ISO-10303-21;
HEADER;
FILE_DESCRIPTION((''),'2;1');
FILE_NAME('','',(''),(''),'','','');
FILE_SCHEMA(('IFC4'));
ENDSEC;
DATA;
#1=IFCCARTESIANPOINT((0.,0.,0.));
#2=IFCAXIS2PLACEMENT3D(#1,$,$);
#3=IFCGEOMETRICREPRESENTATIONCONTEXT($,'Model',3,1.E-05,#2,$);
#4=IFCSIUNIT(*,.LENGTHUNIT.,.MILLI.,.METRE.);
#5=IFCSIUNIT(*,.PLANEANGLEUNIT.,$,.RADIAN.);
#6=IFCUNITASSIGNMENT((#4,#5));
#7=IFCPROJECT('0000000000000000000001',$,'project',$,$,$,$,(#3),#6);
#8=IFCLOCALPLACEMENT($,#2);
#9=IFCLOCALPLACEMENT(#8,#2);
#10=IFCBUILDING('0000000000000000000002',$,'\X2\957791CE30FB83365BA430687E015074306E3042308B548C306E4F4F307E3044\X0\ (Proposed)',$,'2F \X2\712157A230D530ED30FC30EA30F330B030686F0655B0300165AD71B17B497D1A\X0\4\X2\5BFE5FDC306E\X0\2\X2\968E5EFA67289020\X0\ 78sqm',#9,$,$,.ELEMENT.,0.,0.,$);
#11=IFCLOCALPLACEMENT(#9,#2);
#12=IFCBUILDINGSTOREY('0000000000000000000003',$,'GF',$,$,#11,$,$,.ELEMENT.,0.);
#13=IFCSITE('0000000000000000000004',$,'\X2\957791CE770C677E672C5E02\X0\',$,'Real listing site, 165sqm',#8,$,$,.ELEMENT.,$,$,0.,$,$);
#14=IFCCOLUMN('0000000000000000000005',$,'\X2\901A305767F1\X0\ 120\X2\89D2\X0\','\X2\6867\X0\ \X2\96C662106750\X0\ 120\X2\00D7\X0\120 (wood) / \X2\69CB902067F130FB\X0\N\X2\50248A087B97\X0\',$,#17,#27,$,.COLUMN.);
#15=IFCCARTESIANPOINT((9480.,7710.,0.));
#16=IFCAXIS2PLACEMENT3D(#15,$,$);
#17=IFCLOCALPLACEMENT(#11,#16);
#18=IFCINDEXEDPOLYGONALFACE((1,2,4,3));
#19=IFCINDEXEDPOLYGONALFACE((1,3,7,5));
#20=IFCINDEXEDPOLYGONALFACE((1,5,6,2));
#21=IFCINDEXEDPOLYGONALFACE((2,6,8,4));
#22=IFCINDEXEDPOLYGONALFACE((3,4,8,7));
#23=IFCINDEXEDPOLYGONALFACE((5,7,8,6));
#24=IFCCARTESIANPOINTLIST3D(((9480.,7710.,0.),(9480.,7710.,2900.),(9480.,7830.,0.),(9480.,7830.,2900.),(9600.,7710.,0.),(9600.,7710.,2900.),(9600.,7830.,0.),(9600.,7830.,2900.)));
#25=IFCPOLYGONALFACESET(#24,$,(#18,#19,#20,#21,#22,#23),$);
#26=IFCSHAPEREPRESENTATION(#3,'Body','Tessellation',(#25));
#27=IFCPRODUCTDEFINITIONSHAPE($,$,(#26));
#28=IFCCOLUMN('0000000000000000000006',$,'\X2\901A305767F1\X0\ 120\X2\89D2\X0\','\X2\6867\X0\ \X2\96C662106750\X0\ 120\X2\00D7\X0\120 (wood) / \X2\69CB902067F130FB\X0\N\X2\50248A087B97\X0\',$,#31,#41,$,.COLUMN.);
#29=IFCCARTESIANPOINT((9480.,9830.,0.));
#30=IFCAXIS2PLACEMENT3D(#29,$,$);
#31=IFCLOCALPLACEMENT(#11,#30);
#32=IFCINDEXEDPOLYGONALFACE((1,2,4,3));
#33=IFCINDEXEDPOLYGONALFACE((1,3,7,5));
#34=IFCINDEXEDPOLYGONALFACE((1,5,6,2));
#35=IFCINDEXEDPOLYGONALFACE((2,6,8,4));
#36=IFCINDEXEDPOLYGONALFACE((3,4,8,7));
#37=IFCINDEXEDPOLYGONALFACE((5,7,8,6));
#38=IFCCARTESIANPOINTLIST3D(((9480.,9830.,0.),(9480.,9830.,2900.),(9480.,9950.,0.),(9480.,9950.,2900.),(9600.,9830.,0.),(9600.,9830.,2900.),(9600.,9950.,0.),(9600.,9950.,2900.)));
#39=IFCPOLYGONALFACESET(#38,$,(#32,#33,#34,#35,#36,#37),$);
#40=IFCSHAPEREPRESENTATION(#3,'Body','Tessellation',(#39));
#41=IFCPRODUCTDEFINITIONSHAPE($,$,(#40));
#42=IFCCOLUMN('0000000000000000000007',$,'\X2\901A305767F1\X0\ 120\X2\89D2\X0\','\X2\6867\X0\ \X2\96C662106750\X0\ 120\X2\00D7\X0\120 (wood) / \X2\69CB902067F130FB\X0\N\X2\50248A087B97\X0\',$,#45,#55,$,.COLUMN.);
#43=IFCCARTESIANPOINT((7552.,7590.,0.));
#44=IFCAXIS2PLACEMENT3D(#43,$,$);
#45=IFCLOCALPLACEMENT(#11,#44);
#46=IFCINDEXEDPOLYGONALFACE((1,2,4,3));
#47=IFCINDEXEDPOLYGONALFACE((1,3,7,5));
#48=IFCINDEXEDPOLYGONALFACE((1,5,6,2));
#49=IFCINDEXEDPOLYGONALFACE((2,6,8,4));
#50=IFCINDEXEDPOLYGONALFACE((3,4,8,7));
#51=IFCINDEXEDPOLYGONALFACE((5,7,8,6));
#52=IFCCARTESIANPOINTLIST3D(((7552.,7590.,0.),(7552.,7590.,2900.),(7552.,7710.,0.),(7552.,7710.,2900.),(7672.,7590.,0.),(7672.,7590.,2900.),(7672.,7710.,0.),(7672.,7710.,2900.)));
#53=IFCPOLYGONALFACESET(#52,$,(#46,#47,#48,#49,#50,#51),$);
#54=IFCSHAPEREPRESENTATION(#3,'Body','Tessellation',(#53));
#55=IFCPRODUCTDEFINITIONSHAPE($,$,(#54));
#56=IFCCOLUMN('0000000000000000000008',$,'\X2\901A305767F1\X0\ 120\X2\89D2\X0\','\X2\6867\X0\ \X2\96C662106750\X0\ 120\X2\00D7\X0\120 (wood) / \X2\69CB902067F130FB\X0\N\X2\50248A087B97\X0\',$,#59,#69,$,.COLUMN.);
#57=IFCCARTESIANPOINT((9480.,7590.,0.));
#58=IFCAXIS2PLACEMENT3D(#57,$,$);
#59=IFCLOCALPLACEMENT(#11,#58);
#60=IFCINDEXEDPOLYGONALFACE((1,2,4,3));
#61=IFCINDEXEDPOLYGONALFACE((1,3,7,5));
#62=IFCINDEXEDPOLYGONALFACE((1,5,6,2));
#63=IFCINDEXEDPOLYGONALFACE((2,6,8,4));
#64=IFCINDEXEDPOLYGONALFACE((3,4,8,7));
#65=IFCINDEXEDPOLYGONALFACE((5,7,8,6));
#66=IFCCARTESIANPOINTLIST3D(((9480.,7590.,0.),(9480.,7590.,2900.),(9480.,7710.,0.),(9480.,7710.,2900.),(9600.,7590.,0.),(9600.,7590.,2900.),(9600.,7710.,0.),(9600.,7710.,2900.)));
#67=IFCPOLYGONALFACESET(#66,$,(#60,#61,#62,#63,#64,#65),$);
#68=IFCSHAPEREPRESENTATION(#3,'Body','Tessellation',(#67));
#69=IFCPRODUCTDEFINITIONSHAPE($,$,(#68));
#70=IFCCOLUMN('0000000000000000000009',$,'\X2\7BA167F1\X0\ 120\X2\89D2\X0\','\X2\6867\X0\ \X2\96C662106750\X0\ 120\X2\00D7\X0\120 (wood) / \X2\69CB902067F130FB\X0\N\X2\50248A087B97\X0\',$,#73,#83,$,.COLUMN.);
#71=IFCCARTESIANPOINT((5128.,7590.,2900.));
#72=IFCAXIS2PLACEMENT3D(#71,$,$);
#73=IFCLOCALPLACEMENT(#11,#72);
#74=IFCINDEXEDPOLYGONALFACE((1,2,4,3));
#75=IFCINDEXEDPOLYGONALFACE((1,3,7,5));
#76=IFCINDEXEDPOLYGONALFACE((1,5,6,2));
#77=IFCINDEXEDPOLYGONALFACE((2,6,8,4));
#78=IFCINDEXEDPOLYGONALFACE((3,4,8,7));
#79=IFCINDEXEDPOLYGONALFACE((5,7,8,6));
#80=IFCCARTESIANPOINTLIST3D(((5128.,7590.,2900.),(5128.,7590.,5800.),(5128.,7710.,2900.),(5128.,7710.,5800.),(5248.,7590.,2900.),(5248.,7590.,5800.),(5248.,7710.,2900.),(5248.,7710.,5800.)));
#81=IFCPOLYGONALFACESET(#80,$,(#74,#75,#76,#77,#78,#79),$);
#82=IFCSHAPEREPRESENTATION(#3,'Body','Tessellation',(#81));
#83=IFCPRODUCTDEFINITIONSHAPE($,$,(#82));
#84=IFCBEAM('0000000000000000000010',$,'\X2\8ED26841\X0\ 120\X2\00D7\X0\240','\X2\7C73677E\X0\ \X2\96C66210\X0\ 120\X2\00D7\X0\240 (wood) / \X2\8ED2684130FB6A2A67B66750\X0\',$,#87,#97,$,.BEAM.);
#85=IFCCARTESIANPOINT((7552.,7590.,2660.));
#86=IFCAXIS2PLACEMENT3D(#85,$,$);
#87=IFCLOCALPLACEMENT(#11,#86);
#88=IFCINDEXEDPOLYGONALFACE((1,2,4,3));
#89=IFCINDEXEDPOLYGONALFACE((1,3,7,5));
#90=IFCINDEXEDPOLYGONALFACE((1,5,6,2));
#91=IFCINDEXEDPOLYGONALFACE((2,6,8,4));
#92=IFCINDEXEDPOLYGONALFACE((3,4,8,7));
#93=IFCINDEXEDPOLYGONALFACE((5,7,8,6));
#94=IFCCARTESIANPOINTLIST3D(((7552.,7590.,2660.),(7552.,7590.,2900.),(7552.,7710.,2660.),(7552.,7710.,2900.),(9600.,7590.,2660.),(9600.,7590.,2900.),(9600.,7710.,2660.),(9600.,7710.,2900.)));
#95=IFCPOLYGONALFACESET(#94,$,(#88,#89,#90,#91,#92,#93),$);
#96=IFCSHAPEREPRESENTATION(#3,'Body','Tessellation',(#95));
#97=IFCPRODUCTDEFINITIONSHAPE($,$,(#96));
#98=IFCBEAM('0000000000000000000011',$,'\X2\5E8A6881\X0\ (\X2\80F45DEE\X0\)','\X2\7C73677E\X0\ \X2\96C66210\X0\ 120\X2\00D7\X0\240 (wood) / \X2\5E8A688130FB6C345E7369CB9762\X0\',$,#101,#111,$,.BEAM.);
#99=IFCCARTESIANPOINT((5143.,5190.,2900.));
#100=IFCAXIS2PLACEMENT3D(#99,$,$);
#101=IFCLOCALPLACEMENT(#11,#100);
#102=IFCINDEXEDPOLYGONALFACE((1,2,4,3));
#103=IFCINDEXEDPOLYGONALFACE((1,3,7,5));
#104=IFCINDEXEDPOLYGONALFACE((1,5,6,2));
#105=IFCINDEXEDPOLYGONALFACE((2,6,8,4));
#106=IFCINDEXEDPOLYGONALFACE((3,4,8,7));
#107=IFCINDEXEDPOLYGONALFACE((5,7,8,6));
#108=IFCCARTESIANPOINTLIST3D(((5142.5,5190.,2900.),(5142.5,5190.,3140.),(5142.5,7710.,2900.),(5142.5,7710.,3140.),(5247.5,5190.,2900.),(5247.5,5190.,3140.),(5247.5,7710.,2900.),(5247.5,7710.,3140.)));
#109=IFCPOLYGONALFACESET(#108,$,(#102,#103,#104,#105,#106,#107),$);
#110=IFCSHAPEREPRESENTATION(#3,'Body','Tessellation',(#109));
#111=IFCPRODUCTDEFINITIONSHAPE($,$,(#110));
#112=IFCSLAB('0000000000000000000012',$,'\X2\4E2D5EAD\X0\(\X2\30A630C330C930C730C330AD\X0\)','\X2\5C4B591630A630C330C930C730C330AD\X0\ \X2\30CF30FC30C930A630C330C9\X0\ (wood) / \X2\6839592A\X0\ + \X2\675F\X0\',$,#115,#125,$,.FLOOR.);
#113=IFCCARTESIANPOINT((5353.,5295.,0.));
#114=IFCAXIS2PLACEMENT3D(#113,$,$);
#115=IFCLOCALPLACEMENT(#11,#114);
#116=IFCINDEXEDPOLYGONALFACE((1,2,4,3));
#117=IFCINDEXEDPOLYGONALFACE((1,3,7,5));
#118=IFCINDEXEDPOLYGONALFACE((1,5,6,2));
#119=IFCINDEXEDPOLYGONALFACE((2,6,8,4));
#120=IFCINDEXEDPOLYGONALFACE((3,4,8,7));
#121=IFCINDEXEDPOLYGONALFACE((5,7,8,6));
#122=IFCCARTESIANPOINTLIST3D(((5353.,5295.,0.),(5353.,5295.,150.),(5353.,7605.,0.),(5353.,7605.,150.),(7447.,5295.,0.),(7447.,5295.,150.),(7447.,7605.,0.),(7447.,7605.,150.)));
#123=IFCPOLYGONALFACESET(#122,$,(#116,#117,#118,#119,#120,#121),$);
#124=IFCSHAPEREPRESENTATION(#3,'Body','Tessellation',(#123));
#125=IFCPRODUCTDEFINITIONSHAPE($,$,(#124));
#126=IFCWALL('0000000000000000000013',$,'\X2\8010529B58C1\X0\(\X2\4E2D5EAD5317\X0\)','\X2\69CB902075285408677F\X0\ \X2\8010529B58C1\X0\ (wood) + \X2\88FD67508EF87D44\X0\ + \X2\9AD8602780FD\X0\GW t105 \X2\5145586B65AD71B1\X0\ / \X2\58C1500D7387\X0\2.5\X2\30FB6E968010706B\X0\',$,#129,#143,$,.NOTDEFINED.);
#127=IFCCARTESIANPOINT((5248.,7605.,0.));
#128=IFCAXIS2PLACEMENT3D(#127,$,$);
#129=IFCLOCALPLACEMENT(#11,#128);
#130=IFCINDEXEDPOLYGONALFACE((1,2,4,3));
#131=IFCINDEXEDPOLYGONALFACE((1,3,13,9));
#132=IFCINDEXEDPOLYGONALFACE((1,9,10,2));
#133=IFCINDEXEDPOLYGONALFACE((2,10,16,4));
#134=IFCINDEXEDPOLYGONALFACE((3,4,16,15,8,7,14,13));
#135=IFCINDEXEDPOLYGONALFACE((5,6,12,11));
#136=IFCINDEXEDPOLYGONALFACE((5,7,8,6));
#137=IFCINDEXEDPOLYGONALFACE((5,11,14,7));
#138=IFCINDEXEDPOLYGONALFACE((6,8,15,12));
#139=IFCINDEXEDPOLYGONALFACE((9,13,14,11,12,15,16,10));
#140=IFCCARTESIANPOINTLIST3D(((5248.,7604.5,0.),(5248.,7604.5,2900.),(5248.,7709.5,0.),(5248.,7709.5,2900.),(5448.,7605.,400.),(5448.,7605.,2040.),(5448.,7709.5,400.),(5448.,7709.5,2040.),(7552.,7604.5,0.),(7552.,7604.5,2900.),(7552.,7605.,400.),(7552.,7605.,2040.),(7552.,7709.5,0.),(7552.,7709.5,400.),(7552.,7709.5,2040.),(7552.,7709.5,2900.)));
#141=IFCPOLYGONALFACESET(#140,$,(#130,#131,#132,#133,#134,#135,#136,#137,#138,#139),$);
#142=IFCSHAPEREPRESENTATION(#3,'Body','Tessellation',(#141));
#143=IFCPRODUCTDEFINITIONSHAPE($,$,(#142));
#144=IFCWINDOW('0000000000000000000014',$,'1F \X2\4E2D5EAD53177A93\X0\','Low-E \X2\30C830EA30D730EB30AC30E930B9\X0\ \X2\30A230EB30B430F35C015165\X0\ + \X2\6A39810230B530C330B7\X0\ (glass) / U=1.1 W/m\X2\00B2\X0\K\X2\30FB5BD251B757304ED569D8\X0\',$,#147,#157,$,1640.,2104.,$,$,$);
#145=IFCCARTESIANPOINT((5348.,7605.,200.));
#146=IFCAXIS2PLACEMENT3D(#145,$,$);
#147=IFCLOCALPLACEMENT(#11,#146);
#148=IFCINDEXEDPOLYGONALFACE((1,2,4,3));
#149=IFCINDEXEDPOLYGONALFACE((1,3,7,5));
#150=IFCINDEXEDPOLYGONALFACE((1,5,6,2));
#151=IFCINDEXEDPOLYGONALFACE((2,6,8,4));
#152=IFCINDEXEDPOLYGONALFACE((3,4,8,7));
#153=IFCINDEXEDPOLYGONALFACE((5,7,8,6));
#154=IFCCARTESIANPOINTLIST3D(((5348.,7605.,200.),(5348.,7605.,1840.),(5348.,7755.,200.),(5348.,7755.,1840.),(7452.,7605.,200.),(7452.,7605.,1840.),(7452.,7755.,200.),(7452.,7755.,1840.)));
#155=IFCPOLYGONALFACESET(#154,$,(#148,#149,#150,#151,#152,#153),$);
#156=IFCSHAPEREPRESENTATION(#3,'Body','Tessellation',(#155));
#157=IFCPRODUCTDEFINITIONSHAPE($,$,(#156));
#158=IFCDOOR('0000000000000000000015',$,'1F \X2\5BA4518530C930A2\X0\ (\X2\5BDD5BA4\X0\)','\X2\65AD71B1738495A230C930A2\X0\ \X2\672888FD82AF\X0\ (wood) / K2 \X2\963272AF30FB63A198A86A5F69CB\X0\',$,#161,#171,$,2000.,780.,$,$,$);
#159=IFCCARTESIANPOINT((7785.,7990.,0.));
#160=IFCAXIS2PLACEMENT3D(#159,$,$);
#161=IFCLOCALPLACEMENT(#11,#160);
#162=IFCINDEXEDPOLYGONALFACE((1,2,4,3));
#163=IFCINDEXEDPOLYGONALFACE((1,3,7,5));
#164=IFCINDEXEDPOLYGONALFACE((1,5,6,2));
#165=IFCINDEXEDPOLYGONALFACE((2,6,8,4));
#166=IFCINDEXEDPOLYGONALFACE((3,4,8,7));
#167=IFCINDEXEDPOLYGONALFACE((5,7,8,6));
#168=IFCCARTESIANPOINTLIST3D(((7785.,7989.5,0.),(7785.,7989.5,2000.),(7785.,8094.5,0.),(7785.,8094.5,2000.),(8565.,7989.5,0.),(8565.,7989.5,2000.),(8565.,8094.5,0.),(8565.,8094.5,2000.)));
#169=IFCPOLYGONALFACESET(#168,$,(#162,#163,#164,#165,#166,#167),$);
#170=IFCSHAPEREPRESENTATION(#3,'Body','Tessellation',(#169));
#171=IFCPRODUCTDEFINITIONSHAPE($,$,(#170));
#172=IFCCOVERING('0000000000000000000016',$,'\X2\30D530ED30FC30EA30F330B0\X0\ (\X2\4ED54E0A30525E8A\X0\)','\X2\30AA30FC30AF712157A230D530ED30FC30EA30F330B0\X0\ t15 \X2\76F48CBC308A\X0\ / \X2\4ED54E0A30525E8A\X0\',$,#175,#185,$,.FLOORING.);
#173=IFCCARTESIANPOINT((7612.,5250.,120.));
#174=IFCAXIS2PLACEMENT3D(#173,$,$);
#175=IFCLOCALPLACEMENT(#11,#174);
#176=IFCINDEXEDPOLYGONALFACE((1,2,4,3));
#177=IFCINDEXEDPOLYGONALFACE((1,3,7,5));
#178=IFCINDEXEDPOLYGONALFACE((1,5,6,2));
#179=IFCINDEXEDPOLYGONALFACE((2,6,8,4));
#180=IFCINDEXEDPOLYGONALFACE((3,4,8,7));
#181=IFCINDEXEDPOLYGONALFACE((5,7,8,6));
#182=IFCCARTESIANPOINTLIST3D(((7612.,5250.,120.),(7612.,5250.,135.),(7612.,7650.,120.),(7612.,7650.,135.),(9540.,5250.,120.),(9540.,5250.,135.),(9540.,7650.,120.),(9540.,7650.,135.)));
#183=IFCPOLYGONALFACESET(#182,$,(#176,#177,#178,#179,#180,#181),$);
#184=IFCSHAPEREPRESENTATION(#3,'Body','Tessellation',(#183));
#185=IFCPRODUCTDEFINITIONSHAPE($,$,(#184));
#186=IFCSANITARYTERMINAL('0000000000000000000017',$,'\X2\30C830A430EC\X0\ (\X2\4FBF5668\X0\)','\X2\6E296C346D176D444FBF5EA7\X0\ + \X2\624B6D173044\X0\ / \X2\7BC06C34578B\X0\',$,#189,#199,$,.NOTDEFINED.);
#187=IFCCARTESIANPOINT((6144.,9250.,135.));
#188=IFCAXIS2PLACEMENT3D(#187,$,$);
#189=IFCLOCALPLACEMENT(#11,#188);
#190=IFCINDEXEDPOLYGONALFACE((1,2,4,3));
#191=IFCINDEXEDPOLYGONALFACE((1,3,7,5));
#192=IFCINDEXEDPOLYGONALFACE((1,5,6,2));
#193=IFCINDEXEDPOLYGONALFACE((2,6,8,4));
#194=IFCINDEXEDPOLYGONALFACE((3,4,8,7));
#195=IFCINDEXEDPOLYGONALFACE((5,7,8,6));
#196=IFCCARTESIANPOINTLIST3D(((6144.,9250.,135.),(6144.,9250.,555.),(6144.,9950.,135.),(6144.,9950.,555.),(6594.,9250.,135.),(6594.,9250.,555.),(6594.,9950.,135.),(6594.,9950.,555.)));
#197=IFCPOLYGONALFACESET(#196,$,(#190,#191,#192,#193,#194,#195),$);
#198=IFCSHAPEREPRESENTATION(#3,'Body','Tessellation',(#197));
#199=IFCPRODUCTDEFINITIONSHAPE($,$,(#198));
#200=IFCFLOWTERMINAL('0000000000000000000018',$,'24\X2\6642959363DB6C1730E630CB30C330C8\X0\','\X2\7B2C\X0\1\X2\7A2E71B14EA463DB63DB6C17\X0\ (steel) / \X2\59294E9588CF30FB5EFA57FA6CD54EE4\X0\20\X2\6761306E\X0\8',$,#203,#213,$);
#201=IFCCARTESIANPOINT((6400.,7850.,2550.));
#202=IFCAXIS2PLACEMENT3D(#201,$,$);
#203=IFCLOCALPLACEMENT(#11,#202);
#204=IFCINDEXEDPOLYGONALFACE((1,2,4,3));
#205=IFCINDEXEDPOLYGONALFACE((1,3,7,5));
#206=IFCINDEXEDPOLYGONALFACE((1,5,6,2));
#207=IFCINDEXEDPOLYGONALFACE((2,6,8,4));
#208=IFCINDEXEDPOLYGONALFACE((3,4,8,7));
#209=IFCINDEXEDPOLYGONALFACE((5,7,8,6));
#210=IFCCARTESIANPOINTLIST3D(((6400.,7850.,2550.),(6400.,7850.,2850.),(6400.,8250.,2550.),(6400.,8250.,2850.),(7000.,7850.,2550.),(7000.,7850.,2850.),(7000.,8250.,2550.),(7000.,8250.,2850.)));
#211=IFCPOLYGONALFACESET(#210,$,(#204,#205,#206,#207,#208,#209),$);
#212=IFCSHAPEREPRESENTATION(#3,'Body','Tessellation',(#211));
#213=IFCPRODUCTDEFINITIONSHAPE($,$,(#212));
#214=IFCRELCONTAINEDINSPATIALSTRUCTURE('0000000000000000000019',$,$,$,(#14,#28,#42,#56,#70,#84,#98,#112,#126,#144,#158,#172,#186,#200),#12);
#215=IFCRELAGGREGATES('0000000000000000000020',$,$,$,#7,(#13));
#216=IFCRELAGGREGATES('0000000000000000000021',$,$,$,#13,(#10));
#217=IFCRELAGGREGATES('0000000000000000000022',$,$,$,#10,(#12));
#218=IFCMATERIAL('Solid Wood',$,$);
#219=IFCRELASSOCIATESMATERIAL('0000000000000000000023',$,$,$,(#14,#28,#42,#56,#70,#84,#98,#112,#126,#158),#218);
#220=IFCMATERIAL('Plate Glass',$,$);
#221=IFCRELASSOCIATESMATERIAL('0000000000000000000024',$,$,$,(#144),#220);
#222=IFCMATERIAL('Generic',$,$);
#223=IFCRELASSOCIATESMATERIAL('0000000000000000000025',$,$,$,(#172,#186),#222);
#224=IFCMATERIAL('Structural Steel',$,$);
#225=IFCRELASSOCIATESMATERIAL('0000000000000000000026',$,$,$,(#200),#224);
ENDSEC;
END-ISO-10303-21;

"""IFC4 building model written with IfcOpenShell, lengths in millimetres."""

from ifc_helpers import new_model, si_unit, frame, frame_2d, origin, place, context, project, spatial, rectangle, extrude, material, element, fill, save


model = new_model("IFC4")

# Units and contexts
model_context = context("Model", 3, precision=1e-05, world=origin())
ifc_project = project(units=[si_unit("LENGTHUNIT", "METRE", prefix="MILLI"), si_unit("PLANEANGLEUNIT", "RADIAN")], contexts=[model_context])

# Site, building, storey
site_placement = place(None, origin())
site = spatial("IfcSite", under=ifc_project, at=site_placement, Name="長野県松本市", ObjectType="Real listing site, 165sqm", CompositionType="ELEMENT", RefElevation=0.0)
building_placement = place(site_placement, origin())
building = spatial("IfcBuilding", under=site, at=building_placement, Name="長野・茶室と縁側のある和の住まい (Proposed)", ObjectType="2F 無垢フローリングと漆喰、断熱等級4対応の2階建木造 78sqm", CompositionType="ELEMENT", ElevationOfRefHeight=0.0, ElevationOfTerrain=0.0)
storey_placement = place(building_placement, origin())
storey = spatial("IfcBuildingStorey", under=building, at=storey_placement, Name="GF", CompositionType="ELEMENT", Elevation=0.0)

# Columns
ifc_material_1 = material(Name="Solid Wood")
column_1_placement = place(storey_placement, frame((9480.0, 7710.0, 0.0)))
element("IfcColumn", 1, at=column_1_placement, inside=storey, material=ifc_material_1, Name="通し柱 120角", Description="桧 集成材 120×120 (wood) / 構造柱・N値計算", PredefinedType="COLUMN", context=model_context, shape_type="SweptSolid", body=[
    extrude(rectangle(XDim=120.0, YDim=120.0, at=frame_2d((60.0, 60.0))), frame((9480.0, 7710.0, 0.0)), (0.0, 0.0, 1.0), 2900.0),
])
column_2_placement = place(storey_placement, frame((9480.0, 9830.0, 0.0)))
element("IfcColumn", 2, at=column_2_placement, inside=storey, material=ifc_material_1, Name="通し柱 120角", Description="桧 集成材 120×120 (wood) / 構造柱・N値計算", PredefinedType="COLUMN", context=model_context, shape_type="SweptSolid", body=[
    extrude(rectangle(XDim=120.0, YDim=120.0, at=frame_2d((60.0, 60.0))), frame((9480.0, 9830.0, 0.0)), (0.0, 0.0, 1.0), 2900.0),
])
column_3_placement = place(storey_placement, frame((7552.0, 7590.0, 0.0)))
element("IfcColumn", 3, at=column_3_placement, inside=storey, material=ifc_material_1, Name="通し柱 120角", Description="桧 集成材 120×120 (wood) / 構造柱・N値計算", PredefinedType="COLUMN", context=model_context, shape_type="SweptSolid", body=[
    extrude(rectangle(XDim=120.0, YDim=120.0, at=frame_2d((60.0, 60.0))), frame((7552.0, 7590.0, 0.0)), (0.0, 0.0, 1.0), 2900.0),
])
column_4_placement = place(storey_placement, frame((9480.0, 7590.0, 0.0)))
element("IfcColumn", 4, at=column_4_placement, inside=storey, material=ifc_material_1, Name="通し柱 120角", Description="桧 集成材 120×120 (wood) / 構造柱・N値計算", PredefinedType="COLUMN", context=model_context, shape_type="SweptSolid", body=[
    extrude(rectangle(XDim=120.0, YDim=120.0, at=frame_2d((60.0, 60.0))), frame((9480.0, 7590.0, 0.0)), (0.0, 0.0, 1.0), 2900.0),
])
column_5_placement = place(storey_placement, frame((5128.0, 7590.0, 2900.0)))
element("IfcColumn", 5, at=column_5_placement, inside=storey, material=ifc_material_1, Name="管柱 120角", Description="桧 集成材 120×120 (wood) / 構造柱・N値計算", PredefinedType="COLUMN", context=model_context, shape_type="SweptSolid", body=[
    extrude(rectangle(XDim=120.0, YDim=120.0, at=frame_2d((60.0, 60.0))), frame((5128.0, 7590.0, 2900.0)), (0.0, 0.0, 1.0), 2900.0),
])

# Beams
beam_1_placement = place(storey_placement, frame((7552.0, 7590.0, 2660.0)))
element("IfcBeam", 6, at=beam_1_placement, inside=storey, material=ifc_material_1, Name="軒桁 120×240", Description="米松 集成 120×240 (wood) / 軒桁・横架材", PredefinedType="BEAM", context=model_context, shape_type="SweptSolid", body=[
    extrude(rectangle(XDim=2048.0, YDim=120.0, at=frame_2d((1024.0, 60.0))), frame((7552.0, 7590.0, 2660.0)), (0.0, 0.0, 1.0), 240.0),
])
beam_2_placement = place(storey_placement, frame((5143.0, 5190.0, 2900.0)))
element("IfcBeam", 7, at=beam_2_placement, inside=storey, material=ifc_material_1, Name="床梁 (胴差)", Description="米松 集成 120×240 (wood) / 床梁・水平構面", PredefinedType="BEAM", context=model_context, shape_type="SweptSolid", body=[
    extrude(rectangle(XDim=105.0, YDim=2520.0, at=frame_2d((52.0, 1260.0))), frame((5143.0, 5190.0, 2900.0)), (0.0, 0.0, 1.0), 240.0),
])

# Slab
slab_placement = place(storey_placement, frame((5353.0, 5295.0, 0.0)))
element("IfcSlab", 8, at=slab_placement, inside=storey, material=ifc_material_1, Name="中庭(ウッドデッキ)", Description="屋外ウッドデッキ ハードウッド (wood) / 根太 + 束", PredefinedType="FLOOR", context=model_context, shape_type="SweptSolid", body=[
    extrude(rectangle(XDim=2094.0, YDim=2310.0, at=frame_2d((1047.0, 1155.0))), frame((5353.0, 5295.0, 0.0)), (0.0, 0.0, 1.0), 150.0),
])

# Wall, opening, window
wall_1_placement = place(storey_placement, frame((5248.0, 7605.0, 0.0)))
wall_1 = element("IfcWall", 9, at=wall_1_placement, inside=storey, material=ifc_material_1, Name="耐力壁(中庭北)", Description="構造用合板 耐力壁 (wood) + 製材軸組 + 高性能GW t105 充填断熱 / 壁倍率2.5・準耐火", PredefinedType="NOTDEFINED", context=model_context, shape_type="SweptSolid", body=[
    extrude(rectangle(XDim=2304.0, YDim=105.0, at=frame_2d((1152.0, 52.0))), frame((5248.0, 7605.0, 0.0)), (0.0, 0.0, 1.0), 2900.0),
])
opening_placement = place(storey_placement, frame((5348.0, 7605.0, 200.0)))
opening = element("IfcOpeningElement", 10, at=opening_placement, cuts=wall_1, PredefinedType="NOTDEFINED", context=model_context, shape_type="SweptSolid", body=[
    extrude(rectangle(XDim=2104.0, YDim=150.0, at=frame_2d((1052.0, 75.0))), frame((5348.0, 7605.0, 200.0)), (0.0, 0.0, 1.0), 1640.0),
])
ifc_material_2 = material(Name="Plate Glass")
window_placement = place(storey_placement, frame((5348.0, 7605.0, 200.0)))
window = element("IfcWindow", 11, at=window_placement, inside=storey, material=ifc_material_2, Name="1F 中庭北窓", Description="Low-E トリプルガラス アルゴン封入 + 樹脂サッシ (glass) / U=1.1 W/m²K・寒冷地仕様", OverallHeight=1640.0, OverallWidth=2104.0, context=model_context, shape_type="SweptSolid", body=[
    extrude(rectangle(XDim=2104.0, YDim=150.0, at=frame_2d((1052.0, 75.0))), frame((5348.0, 7605.0, 200.0)), (0.0, 0.0, 1.0), 1640.0),
])
fill(opening, window)

# Door
door_placement = place(storey_placement, frame((7785.0, 7990.0, 0.0)))
element("IfcDoor", 12, at=door_placement, inside=storey, material=ifc_material_1, Name="1F 室内ドア (寝室)", Description="断熱玄関ドア 木製芯 (wood) / K2 防犯・採風機構", OverallHeight=2000.0, OverallWidth=780.0, context=model_context, shape_type="SweptSolid", body=[
    extrude(rectangle(XDim=780.0, YDim=105.0, at=frame_2d((390.0, 52.0))), frame((7785.0, 7990.0, 0.0)), (0.0, 0.0, 1.0), 2000.0),
])

# Covering
ifc_material_3 = material(Name="Generic")
covering_placement = place(storey_placement, frame((7612.0, 5250.0, 120.0)))
element("IfcCovering", 13, at=covering_placement, inside=storey, material=ifc_material_3, Name="フローリング (仕上げ床)", Description="オーク無垢フローリング t15 直貼り / 仕上げ床", PredefinedType="FLOORING", context=model_context, shape_type="SweptSolid", body=[
    extrude(rectangle(XDim=1928.0, YDim=2400.0, at=frame_2d((964.0, 1200.0))), frame((7612.0, 5250.0, 120.0)), (0.0, 0.0, 1.0), 15.0),
])

# Sanitary terminal
sanitary_terminal_placement = place(storey_placement, frame((6144.0, 9250.0, 135.0)))
element("IfcSanitaryTerminal", 14, at=sanitary_terminal_placement, inside=storey, material=ifc_material_3, Name="トイレ (便器)", Description="温水洗浄便座 + 手洗い / 節水型", PredefinedType="NOTDEFINED", context=model_context, shape_type="SweptSolid", body=[
    extrude(rectangle(XDim=450.0, YDim=700.0, at=frame_2d((225.0, 350.0))), frame((6144.0, 9250.0, 135.0)), (0.0, 0.0, 1.0), 420.0),
])

# Flow terminal
ifc_material_4 = material(Name="Structural Steel")
flow_terminal_placement = place(storey_placement, frame((6400.0, 7850.0, 2550.0)))
element("IfcFlowTerminal", 15, at=flow_terminal_placement, inside=storey, material=ifc_material_4, Name="24時間換気ユニット", Description="第1種熱交換換気 (steel) / 天井裏・建基法令20条の8", context=model_context, shape_type="SweptSolid", body=[
    extrude(rectangle(XDim=600.0, YDim=400.0, at=frame_2d((300.0, 200.0))), frame((6400.0, 7850.0, 2550.0)), (0.0, 0.0, 1.0), 300.0),
])

save(model, "model.ifc")
